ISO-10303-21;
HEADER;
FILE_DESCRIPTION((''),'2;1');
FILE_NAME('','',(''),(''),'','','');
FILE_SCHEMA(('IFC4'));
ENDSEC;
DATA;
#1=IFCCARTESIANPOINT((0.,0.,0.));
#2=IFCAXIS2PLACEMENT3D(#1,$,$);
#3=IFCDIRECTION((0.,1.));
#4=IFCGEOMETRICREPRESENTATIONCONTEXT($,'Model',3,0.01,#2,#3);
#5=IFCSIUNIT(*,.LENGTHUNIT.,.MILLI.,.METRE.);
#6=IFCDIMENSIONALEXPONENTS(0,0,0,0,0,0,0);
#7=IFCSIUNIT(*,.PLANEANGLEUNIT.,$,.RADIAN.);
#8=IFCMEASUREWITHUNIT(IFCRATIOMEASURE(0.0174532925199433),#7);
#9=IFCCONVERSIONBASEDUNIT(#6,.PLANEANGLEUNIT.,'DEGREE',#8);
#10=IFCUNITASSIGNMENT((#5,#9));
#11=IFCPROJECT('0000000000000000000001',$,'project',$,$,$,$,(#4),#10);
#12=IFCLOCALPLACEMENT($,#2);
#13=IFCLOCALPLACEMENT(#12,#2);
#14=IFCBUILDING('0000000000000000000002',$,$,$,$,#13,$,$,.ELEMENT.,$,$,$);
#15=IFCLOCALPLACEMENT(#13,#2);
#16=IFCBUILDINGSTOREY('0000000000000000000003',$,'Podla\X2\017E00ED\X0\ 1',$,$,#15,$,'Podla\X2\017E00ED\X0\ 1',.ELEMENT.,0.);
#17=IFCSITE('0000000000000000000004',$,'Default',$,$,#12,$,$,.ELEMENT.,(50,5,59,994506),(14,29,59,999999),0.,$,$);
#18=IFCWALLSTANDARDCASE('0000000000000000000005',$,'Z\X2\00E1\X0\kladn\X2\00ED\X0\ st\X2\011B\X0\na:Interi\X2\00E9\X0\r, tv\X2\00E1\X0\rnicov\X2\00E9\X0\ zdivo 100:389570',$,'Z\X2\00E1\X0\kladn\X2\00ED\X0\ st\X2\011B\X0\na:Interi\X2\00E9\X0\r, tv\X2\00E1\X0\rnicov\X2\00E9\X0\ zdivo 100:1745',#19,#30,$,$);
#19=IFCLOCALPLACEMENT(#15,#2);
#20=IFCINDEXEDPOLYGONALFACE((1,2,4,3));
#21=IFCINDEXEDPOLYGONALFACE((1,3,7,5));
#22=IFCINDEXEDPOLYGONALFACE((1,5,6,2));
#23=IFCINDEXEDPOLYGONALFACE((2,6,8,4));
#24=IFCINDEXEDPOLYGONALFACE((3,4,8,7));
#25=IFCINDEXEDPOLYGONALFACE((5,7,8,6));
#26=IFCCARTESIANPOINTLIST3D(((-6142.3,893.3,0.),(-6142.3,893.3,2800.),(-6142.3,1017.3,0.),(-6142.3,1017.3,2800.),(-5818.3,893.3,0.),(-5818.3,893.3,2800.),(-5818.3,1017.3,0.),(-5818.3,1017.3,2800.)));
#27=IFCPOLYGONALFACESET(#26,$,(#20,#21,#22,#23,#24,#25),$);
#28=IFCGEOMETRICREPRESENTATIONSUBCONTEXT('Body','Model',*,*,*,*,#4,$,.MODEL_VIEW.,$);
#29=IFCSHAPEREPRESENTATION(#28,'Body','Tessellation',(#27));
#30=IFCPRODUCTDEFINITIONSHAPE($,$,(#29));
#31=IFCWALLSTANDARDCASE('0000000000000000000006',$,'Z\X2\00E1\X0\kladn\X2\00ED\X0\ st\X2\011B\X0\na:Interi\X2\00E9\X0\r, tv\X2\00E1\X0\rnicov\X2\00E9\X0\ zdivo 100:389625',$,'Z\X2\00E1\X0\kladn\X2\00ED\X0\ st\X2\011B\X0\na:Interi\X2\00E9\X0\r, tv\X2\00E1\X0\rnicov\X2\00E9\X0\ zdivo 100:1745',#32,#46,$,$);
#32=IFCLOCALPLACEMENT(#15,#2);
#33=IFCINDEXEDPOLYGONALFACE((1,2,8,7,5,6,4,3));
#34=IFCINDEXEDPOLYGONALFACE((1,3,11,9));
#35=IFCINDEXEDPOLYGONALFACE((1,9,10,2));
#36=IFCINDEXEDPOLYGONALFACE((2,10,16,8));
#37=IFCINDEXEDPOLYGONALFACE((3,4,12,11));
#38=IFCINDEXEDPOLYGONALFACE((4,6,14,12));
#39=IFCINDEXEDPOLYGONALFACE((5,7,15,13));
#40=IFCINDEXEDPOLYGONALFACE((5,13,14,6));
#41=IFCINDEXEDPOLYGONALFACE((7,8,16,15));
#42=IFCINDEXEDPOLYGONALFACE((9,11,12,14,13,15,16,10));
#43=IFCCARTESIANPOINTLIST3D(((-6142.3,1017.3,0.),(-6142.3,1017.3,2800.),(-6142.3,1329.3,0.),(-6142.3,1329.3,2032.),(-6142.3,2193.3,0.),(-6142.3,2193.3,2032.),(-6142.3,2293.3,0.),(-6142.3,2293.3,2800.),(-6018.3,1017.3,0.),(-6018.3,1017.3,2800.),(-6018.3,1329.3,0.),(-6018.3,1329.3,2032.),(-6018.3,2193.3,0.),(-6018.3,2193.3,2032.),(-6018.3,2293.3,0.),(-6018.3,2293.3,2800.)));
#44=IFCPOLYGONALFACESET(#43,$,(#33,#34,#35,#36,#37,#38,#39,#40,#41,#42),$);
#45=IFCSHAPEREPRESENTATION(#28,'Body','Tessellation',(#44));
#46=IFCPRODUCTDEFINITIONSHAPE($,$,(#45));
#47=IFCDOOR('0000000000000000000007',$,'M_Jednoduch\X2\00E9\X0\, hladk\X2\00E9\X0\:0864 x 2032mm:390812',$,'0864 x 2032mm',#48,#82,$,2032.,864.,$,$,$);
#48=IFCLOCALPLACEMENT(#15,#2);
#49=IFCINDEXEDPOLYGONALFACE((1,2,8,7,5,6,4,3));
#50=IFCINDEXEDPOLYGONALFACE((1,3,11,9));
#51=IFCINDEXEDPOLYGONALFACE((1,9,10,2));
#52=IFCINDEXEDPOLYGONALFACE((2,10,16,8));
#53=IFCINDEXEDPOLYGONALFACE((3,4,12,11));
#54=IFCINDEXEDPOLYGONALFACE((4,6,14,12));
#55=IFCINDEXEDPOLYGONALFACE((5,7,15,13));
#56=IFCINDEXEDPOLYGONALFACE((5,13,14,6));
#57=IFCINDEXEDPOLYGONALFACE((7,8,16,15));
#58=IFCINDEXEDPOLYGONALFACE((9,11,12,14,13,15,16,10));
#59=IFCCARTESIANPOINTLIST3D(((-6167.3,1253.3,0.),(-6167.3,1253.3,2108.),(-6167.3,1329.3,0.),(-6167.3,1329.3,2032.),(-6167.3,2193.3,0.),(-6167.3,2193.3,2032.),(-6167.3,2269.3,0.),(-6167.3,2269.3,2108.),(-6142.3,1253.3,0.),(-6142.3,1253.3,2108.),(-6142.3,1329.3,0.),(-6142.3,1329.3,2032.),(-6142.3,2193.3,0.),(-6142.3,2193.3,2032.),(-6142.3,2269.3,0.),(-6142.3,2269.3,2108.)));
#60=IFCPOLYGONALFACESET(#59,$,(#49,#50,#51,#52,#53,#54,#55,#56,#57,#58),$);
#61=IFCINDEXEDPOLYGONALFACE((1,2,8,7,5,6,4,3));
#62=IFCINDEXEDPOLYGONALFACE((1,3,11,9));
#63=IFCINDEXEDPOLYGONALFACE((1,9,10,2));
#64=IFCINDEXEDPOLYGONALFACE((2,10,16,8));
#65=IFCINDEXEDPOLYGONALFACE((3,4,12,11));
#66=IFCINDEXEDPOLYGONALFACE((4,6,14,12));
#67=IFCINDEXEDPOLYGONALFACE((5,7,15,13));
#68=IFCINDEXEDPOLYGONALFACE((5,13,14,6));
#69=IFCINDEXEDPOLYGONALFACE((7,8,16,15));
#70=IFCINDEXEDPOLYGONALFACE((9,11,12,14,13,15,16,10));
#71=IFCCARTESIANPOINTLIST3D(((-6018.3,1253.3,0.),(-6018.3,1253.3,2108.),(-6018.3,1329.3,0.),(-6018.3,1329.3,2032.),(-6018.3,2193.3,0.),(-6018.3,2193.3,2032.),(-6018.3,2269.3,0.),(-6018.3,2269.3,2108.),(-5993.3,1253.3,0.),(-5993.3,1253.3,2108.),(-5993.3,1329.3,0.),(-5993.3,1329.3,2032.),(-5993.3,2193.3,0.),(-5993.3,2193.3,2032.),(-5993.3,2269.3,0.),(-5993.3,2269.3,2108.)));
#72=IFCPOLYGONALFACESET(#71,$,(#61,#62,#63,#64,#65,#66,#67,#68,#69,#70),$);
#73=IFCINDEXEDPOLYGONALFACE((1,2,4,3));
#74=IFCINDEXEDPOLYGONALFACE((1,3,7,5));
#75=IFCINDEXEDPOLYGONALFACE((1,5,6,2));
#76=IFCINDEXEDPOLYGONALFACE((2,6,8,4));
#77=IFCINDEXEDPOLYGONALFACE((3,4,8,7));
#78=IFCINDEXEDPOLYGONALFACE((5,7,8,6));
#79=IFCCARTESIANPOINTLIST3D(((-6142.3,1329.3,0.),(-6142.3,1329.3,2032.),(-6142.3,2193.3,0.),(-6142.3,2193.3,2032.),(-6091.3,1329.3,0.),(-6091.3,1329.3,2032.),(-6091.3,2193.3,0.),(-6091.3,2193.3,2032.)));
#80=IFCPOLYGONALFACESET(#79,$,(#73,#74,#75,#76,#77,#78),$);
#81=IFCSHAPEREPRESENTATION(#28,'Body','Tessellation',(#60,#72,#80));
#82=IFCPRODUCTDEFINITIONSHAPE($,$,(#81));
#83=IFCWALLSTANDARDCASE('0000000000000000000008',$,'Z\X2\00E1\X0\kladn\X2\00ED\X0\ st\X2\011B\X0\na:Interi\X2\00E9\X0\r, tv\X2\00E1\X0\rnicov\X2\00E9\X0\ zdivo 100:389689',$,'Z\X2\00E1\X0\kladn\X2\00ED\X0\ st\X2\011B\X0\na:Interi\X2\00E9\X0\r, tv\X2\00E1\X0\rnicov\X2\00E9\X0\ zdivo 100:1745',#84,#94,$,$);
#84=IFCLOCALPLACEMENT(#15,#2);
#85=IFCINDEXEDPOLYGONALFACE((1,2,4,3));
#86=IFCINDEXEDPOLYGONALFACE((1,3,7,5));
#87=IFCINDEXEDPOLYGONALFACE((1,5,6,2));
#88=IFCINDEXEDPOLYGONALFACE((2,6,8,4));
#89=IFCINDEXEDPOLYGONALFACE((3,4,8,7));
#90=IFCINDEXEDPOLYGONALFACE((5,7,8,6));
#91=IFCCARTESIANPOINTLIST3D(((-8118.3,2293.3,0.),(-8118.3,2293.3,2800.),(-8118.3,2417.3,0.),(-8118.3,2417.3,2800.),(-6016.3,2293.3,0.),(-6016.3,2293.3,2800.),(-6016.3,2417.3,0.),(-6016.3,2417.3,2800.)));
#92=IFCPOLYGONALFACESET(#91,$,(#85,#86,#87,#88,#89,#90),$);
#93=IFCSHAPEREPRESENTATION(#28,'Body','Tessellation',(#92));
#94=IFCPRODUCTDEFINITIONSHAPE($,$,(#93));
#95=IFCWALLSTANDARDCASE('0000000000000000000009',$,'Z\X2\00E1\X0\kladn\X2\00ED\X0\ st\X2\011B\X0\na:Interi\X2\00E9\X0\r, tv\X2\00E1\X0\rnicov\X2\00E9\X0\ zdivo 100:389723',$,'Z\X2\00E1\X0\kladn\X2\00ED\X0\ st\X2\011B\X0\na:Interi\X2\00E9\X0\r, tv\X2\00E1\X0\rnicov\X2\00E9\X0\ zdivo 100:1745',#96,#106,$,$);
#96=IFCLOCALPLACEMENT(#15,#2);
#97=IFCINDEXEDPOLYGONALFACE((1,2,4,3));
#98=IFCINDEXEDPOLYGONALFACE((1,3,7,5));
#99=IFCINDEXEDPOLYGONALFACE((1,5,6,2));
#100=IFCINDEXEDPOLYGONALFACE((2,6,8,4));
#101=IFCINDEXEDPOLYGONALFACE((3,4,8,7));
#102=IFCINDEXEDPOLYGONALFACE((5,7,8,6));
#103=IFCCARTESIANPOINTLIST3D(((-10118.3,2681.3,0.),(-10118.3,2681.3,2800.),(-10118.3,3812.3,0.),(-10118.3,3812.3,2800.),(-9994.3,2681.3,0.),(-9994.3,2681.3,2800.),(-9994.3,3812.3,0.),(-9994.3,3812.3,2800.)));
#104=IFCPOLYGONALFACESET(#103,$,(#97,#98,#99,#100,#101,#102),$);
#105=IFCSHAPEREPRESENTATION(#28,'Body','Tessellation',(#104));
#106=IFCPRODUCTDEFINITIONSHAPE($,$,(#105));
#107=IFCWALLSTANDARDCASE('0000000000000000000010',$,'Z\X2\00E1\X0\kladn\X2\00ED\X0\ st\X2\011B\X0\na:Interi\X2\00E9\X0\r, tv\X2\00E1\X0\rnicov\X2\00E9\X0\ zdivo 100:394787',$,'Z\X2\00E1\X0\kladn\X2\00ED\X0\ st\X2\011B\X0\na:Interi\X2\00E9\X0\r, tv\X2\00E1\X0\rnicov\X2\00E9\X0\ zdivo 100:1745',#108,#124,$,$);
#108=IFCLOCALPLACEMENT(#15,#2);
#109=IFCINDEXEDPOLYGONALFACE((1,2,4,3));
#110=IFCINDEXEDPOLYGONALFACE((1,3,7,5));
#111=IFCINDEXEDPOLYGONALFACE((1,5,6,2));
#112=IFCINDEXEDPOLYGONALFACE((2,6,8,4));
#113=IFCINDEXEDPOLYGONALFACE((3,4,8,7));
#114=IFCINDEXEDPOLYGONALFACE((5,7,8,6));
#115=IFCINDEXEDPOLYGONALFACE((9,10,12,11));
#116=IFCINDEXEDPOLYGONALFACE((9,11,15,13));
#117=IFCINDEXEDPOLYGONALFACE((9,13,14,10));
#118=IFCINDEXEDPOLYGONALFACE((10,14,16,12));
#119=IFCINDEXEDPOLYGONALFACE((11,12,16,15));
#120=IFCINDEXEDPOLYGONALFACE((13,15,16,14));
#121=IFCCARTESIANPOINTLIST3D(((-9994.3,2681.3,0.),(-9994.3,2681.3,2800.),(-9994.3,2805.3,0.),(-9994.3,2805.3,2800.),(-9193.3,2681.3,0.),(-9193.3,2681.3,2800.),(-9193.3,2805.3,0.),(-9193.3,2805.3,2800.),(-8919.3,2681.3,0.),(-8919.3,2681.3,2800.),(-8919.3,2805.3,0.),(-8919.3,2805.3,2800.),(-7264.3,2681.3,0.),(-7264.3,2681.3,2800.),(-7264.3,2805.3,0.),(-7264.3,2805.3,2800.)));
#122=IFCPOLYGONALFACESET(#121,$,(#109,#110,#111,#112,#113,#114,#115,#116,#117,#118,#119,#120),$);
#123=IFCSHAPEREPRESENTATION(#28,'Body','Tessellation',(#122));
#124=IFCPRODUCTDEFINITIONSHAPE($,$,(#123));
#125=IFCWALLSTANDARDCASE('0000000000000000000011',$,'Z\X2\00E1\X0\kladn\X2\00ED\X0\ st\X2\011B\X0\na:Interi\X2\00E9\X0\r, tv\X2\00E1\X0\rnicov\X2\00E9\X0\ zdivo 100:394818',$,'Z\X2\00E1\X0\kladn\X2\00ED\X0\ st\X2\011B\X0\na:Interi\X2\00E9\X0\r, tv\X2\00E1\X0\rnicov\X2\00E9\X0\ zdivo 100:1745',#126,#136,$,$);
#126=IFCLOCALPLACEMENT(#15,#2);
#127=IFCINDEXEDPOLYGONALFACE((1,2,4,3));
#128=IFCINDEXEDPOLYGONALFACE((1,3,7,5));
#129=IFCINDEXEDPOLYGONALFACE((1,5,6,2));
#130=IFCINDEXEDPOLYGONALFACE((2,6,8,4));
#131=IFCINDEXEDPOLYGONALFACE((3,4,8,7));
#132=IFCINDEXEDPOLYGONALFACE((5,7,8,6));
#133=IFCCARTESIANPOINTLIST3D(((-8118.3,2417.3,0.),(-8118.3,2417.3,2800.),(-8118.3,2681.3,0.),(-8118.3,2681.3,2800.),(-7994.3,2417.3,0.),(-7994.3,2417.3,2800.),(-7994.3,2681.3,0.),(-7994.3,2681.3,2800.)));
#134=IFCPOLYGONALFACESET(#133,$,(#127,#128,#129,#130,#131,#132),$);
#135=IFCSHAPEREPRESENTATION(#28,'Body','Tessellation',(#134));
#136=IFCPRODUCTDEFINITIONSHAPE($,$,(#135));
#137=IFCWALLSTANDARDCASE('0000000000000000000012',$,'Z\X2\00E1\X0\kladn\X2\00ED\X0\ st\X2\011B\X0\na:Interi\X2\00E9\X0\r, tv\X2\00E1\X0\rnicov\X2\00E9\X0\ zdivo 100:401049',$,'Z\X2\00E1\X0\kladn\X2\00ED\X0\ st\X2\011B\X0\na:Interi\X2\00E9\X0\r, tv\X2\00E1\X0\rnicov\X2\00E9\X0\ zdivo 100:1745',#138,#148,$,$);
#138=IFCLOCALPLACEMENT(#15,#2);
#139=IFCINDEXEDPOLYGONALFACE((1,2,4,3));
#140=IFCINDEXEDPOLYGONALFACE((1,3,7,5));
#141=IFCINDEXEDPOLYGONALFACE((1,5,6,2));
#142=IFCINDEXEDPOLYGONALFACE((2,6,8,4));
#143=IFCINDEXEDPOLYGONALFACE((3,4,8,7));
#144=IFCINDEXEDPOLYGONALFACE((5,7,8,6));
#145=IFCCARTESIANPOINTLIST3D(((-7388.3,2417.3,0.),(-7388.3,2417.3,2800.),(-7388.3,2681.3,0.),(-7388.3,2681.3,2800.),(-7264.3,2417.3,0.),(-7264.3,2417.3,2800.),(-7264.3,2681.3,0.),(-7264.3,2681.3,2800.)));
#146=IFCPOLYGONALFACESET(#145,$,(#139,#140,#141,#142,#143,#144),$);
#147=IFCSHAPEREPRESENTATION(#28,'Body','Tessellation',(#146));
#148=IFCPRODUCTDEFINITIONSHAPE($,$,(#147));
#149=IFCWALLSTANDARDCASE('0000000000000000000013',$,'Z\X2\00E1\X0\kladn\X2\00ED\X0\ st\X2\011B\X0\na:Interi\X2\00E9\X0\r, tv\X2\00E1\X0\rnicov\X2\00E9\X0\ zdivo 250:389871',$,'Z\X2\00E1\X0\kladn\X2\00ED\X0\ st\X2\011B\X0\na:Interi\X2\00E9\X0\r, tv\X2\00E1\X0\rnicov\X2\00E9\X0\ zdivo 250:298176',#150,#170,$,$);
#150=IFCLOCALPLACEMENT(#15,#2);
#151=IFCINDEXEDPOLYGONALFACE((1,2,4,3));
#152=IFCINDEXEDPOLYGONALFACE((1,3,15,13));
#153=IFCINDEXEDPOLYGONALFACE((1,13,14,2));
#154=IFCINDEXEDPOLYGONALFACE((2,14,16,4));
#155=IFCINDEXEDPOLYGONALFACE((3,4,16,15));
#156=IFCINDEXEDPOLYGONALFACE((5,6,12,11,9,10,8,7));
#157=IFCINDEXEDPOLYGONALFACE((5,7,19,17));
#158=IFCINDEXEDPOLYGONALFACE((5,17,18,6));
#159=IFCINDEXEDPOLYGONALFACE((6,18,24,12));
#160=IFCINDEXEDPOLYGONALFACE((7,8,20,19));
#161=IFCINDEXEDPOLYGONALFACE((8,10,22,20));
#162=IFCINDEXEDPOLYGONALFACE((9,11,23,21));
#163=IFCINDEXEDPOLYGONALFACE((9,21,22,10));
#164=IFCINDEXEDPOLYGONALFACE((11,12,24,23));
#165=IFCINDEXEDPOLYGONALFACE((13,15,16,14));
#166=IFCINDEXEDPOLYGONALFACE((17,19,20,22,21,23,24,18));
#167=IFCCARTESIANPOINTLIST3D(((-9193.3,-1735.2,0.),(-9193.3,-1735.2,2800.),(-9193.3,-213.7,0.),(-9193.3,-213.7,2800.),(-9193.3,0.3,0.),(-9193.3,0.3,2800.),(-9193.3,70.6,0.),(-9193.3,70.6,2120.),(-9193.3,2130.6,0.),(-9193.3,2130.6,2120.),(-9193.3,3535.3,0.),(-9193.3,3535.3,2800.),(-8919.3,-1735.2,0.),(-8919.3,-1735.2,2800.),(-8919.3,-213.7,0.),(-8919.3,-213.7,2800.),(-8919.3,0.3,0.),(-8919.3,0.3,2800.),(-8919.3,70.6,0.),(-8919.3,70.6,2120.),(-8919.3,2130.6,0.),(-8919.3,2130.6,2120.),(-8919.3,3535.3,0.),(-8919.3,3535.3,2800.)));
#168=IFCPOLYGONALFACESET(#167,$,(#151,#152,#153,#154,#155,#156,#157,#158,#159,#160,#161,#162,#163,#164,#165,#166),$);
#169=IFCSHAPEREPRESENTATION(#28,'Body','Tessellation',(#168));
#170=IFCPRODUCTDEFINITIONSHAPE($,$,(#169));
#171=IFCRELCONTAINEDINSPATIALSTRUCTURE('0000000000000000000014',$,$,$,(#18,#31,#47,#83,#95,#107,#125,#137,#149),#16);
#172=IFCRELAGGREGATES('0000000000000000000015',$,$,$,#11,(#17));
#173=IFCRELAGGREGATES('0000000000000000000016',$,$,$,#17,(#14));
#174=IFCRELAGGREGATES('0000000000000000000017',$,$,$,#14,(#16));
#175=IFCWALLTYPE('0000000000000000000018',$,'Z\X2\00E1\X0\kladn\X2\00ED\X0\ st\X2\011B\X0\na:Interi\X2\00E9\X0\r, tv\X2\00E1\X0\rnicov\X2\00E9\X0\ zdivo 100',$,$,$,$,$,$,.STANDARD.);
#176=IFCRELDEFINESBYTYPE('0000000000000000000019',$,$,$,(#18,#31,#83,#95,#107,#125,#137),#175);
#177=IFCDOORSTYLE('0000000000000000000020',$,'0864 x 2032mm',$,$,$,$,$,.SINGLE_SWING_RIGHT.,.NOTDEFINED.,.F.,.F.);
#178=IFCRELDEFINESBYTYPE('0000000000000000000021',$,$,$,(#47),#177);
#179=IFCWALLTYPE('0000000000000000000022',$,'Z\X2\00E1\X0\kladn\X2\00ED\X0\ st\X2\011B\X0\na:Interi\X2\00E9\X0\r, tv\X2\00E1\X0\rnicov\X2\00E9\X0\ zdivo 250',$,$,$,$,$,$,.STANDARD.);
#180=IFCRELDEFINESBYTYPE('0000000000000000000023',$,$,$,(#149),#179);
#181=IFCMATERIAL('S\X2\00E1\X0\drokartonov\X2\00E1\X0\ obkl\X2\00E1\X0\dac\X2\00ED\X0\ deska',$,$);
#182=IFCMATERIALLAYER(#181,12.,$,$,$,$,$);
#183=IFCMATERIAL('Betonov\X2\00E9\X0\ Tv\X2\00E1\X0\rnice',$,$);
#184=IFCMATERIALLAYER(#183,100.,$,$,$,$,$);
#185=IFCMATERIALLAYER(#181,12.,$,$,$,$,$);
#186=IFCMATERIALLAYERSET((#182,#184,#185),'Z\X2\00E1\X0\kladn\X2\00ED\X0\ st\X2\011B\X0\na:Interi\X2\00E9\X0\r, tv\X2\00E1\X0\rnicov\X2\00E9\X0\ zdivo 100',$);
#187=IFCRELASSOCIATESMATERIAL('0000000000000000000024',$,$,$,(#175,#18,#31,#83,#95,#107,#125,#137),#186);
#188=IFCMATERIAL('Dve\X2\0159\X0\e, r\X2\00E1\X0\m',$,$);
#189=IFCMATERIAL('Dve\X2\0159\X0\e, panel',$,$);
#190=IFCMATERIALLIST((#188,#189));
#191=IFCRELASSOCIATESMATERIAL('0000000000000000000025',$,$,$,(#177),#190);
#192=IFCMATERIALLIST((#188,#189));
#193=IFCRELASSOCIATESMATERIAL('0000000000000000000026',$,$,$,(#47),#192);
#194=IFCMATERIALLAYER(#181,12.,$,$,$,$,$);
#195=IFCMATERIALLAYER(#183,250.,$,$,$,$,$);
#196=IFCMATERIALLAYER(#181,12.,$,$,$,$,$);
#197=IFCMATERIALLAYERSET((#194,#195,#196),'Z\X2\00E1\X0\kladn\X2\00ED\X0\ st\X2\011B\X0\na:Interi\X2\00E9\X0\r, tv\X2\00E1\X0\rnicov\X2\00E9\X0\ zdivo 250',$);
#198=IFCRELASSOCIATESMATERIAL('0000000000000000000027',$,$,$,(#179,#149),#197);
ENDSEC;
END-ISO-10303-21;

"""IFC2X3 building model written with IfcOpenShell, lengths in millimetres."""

from ifc_helpers import new_model, entity, si_unit, converted_unit, direction, frame, frame_2d, origin, origin_2d_with_axis, place, context, subcontext, project, spatial, polyline, rectangle, outline, extrude, source, transform, mapped, material, material_list, layer, layer_set, layer_usage, type_object, type_shapes, element, fill, save


model = new_model("IFC2X3")

# Units and contexts
model_context = context("Model", 3, precision=0.01, world=origin(), true_north=direction((0.0, 1.0)))
body_context = subcontext(model_context, "Body", "Model", "MODEL_VIEW")
ifc_project = project(units=[si_unit("LENGTHUNIT", "METRE", prefix="MILLI"), converted_unit("PLANEANGLEUNIT", "DEGREE", entity("IfcRatioMeasure", 0.0174532925199433), si_unit("PLANEANGLEUNIT", "RADIAN"), dimensions=[0, 0, 0, 0, 0, 0, 0])], contexts=[model_context])

# Site, building, storey
site_placement = place(None, origin())
site = spatial("IfcSite", under=ifc_project, at=site_placement, Name="Default", CompositionType="ELEMENT", RefLatitude=(50, 5, 59, 994506), RefLongitude=(14, 29, 59, 999999), RefElevation=0.0)
building_placement = place(site_placement, origin())
building = spatial("IfcBuilding", under=site, at=building_placement, CompositionType="ELEMENT")
storey_placement = place(building_placement, origin())
storey = spatial("IfcBuildingStorey", under=building, at=storey_placement, Name="Podlaží 1", LongName="Podlaží 1", CompositionType="ELEMENT", Elevation=0.0)

# Shared definitions
ifc_material_1 = material(Name="Betonové Tvárnice")
ifc_material_2 = material(Name="Sádrokartonová obkládací deska")

# Shared definitions
ifc_material_3 = material(Name="Dveře, rám")
ifc_material_4 = material(Name="Dveře, panel")

# Wall
ifc_layer_1 = layer(ifc_material_2, 12.0)
ifc_layer_2 = layer(ifc_material_1, 100.0)
ifc_layer_3 = layer(ifc_material_2, 12.0)
ifc_layer_set_1 = layer_set([ifc_layer_1, ifc_layer_2, ifc_layer_3], Name="Základní stěna:Interiér, tvárnicové zdivo 100")
wall_type_1 = type_object("IfcWallType", Name="Základní stěna:Interiér, tvárnicové zdivo 100", PredefinedType="STANDARD", material=ifc_layer_set_1)
ifc_layer_usage_1 = layer_usage(ifc_layer_set_1, "AXIS2", "NEGATIVE", 62.0)
wall_1_placement = place(storey_placement, frame((-5818.3, 955.3, 0.0), z_axis=(0.0, 0.0, 1.0), x_axis=(-1.0, 0.0, 0.0)))
element("IfcWallStandardCase", 1, at=wall_1_placement, inside=storey, type_object=wall_type_1, material=ifc_layer_usage_1, Name="Základní stěna:Interiér, tvárnicové zdivo 100:389570", ObjectType="Základní stěna:Interiér, tvárnicové zdivo 100:1745", context=body_context, shape_type="SweptSolid", body=[
    extrude(rectangle(XDim=324.0, YDim=124.0, at=frame_2d((162.0, 0.0), x_axis=(-1.0, 0.0))), origin(), (0.0, 0.0, 1.0), 2800.0),
])

# Wall, opening, door
ifc_layer_usage_2 = layer_usage(ifc_layer_set_1, "AXIS2", "NEGATIVE", 62.0)
wall_2_placement = place(storey_placement, frame((-6080.3, 1017.3, 0.0), z_axis=(0.0, 0.0, 1.0), x_axis=(0.0, 1.0, 0.0)))
wall_2 = element("IfcWallStandardCase", 2, at=wall_2_placement, inside=storey, type_object=wall_type_1, material=ifc_layer_usage_2, Name="Základní stěna:Interiér, tvárnicové zdivo 100:389625", ObjectType="Základní stěna:Interiér, tvárnicové zdivo 100:1745", context=body_context, shape_type="SweptSolid", body=[
    extrude(rectangle(XDim=1276.0, YDim=124.0, at=frame_2d((638.0, 0.0), x_axis=(-1.0, 0.0))), origin(), (0.0, 0.0, 1.0), 2800.0),
])
opening_1_placement = place(wall_2_placement, frame((312.0, -62.0, 0.0)))
opening_1 = element("IfcOpeningElement", 3, at=opening_1_placement, cuts=wall_2, ObjectType="Opening", context=body_context, shape_type="SweptSolid", body=[
    extrude(rectangle(XDim=864.0, YDim=2032.0, at=frame_2d((1016.0, 432.0), x_axis=(0.0, 1.0))), frame((0.0, 0.0, 0.0), z_axis=(0.0, 1.0, 0.0), x_axis=(0.0, 0.0, 1.0)), (0.0, 0.0, 1.0), 124.0),
])
ifc_material_list_1 = material_list([ifc_material_3, ifc_material_4])
ifc_material_list_2 = material_list([ifc_material_3, ifc_material_4])
door_style_1 = type_object("IfcDoorStyle", Name="0864 x 2032mm", ConstructionType="NOTDEFINED", OperationType="SINGLE_SWING_RIGHT", ParameterTakesPrecedence=False, Sizeable=False, material=ifc_material_list_2)
shared_shape_1 = source(origin(), body_context, "Body", "SweptSolid", [
    extrude(outline(polyline([(-508.0, -1073.0), (508.0, -1073.0), (508.0, 1035.0), (432.0, 1035.0), (432.0, -997.0), (-432.0, -997.0), (-432.0, 1035.0), (-508.0, 1035.0), (-508.0, -1073.0)])), frame((432.0, 124.0, 1035.0), z_axis=(0.0, 1.0, 0.0), x_axis=(1.0, 0.0, 0.0)), (0.0, 0.0, 1.0), 25.0),
    extrude(outline(polyline([(-1073.0, -508.0), (1035.0, -508.0), (1035.0, -432.0), (-997.0, -432.0), (-997.0, 432.0), (1035.0, 432.0), (1035.0, 508.0), (-1073.0, 508.0), (-1073.0, -508.0)])), frame((432.0, -25.0, 1035.0), z_axis=(0.0, 1.0, 0.0), x_axis=(0.0, 0.0, -1.0)), (0.0, 0.0, 1.0), 25.0),
    extrude(rectangle(XDim=51.0, YDim=864.0, at=origin_2d_with_axis()), frame((432.0, 98.5, 0.0), z_axis=(0.0, 0.0, 1.0), x_axis=(0.0, 1.0, 0.0)), (0.0, 0.0, 1.0), 2032.0),
])
type_shapes(door_style_1, [shared_shape_1])
door_1_placement = place(opening_1_placement, origin())
door_1 = element("IfcDoor", 4, at=door_1_placement, inside=storey, type_object=door_style_1, material=ifc_material_list_1, Name="M_Jednoduché, hladké:0864 x 2032mm:390812", ObjectType="0864 x 2032mm", OverallHeight=2032.0, OverallWidth=864.0, context=body_context, shape_type="MappedRepresentation", body=[
    mapped(shared_shape_1, transform((0.0, 0.0, 0.0), scale=1.0)),
])
fill(opening_1, door_1)

# Walls
ifc_layer_usage_3 = layer_usage(ifc_layer_set_1, "AXIS2", "NEGATIVE", 62.0)
wall_3_placement = place(storey_placement, frame((-6016.3, 2355.3, 0.0), z_axis=(0.0, 0.0, 1.0), x_axis=(-1.0, 0.0, 0.0)))
element("IfcWallStandardCase", 5, at=wall_3_placement, inside=storey, type_object=wall_type_1, material=ifc_layer_usage_3, Name="Základní stěna:Interiér, tvárnicové zdivo 100:389689", ObjectType="Základní stěna:Interiér, tvárnicové zdivo 100:1745", context=body_context, shape_type="SweptSolid", body=[
    extrude(rectangle(XDim=2102.0, YDim=124.0, at=frame_2d((1051.0, 0.0), x_axis=(-1.0, 0.0))), origin(), (0.0, 0.0, 1.0), 2800.0),
])
ifc_layer_usage_4 = layer_usage(ifc_layer_set_1, "AXIS2", "NEGATIVE", 62.0)
wall_4_placement = place(storey_placement, frame((-10056.3, 2681.3, 0.0), z_axis=(0.0, 0.0, 1.0), x_axis=(0.0, 1.0, 0.0)))
element("IfcWallStandardCase", 6, at=wall_4_placement, inside=storey, type_object=wall_type_1, material=ifc_layer_usage_4, Name="Základní stěna:Interiér, tvárnicové zdivo 100:389723", ObjectType="Základní stěna:Interiér, tvárnicové zdivo 100:1745", context=body_context, shape_type="SweptSolid", body=[
    extrude(rectangle(XDim=1131.0, YDim=124.0, at=frame_2d((565.5, 0.0), x_axis=(-1.0, 0.0))), origin(), (0.0, 0.0, 1.0), 2800.0),
])

# Wall, opening
ifc_layer_usage_5 = layer_usage(ifc_layer_set_1, "AXIS2", "NEGATIVE", 62.0)
wall_5_placement = place(storey_placement, frame((-9994.3, 2743.3, 0.0)))
wall_5 = element("IfcWallStandardCase", 7, at=wall_5_placement, inside=storey, type_object=wall_type_1, material=ifc_layer_usage_5, Name="Základní stěna:Interiér, tvárnicové zdivo 100:394787", ObjectType="Základní stěna:Interiér, tvárnicové zdivo 100:1745", context=body_context, shape_type="SweptSolid", body=[
    extrude(rectangle(XDim=2730.0, YDim=124.0, at=frame_2d((1365.0, 0.0), x_axis=(-1.0, 0.0))), origin(), (0.0, 0.0, 1.0), 2800.0),
])
opening_2_placement = place(storey_placement, frame((-9994.3, 2743.3, 0.0)))
element("IfcOpeningElement", 8, at=opening_2_placement, cuts=wall_5, ObjectType="Opening", context=body_context, shape_type="SweptSolid", body=[
    extrude(rectangle(XDim=2800.0, YDim=124.0, at=origin_2d_with_axis()), frame((801.0, 0.0, 1400.0), z_axis=(1.0, 0.0, 0.0), x_axis=(0.0, 0.0, -1.0)), (0.0, 0.0, 1.0), 274.0),
])

# Walls
ifc_layer_usage_6 = layer_usage(ifc_layer_set_1, "AXIS2", "NEGATIVE", 62.0)
wall_6_placement = place(storey_placement, frame((-8056.3, 2681.3, 0.0), z_axis=(0.0, 0.0, 1.0), x_axis=(0.0, -1.0, 0.0)))
element("IfcWallStandardCase", 9, at=wall_6_placement, inside=storey, type_object=wall_type_1, material=ifc_layer_usage_6, Name="Základní stěna:Interiér, tvárnicové zdivo 100:394818", ObjectType="Základní stěna:Interiér, tvárnicové zdivo 100:1745", context=body_context, shape_type="SweptSolid", body=[
    extrude(rectangle(XDim=264.0, YDim=124.0, at=frame_2d((132.0, 0.0), x_axis=(-1.0, 0.0))), origin(), (0.0, 0.0, 1.0), 2800.0),
])
ifc_layer_usage_7 = layer_usage(ifc_layer_set_1, "AXIS2", "NEGATIVE", 62.0)
wall_7_placement = place(storey_placement, frame((-7326.3, 2681.3, 0.0), z_axis=(0.0, 0.0, 1.0), x_axis=(0.0, -1.0, 0.0)))
element("IfcWallStandardCase", 10, at=wall_7_placement, inside=storey, type_object=wall_type_1, material=ifc_layer_usage_7, Name="Základní stěna:Interiér, tvárnicové zdivo 100:401049", ObjectType="Základní stěna:Interiér, tvárnicové zdivo 100:1745", context=body_context, shape_type="SweptSolid", body=[
    extrude(rectangle(XDim=264.0, YDim=124.0, at=frame_2d((132.0, 0.0), x_axis=(-1.0, 0.0))), origin(), (0.0, 0.0, 1.0), 2800.0),
])

# Wall, openings
ifc_layer_4 = layer(ifc_material_2, 12.0)
ifc_layer_5 = layer(ifc_material_1, 250.0)
ifc_layer_6 = layer(ifc_material_2, 12.0)
ifc_layer_set_2 = layer_set([ifc_layer_4, ifc_layer_5, ifc_layer_6], Name="Základní stěna:Interiér, tvárnicové zdivo 250")
ifc_layer_usage_8 = layer_usage(ifc_layer_set_2, "AXIS2", "NEGATIVE", 137.0)
wall_type_2 = type_object("IfcWallType", Name="Základní stěna:Interiér, tvárnicové zdivo 250", PredefinedType="STANDARD", material=ifc_layer_set_2)
wall_8_placement = place(storey_placement, frame((-9056.3, 3535.3, 0.0), z_axis=(0.0, 0.0, 1.0), x_axis=(0.0, -1.0, 0.0)))
wall_8 = element("IfcWallStandardCase", 11, at=wall_8_placement, inside=storey, type_object=wall_type_2, material=ifc_layer_usage_8, Name="Základní stěna:Interiér, tvárnicové zdivo 250:389871", ObjectType="Základní stěna:Interiér, tvárnicové zdivo 250:298176", context=body_context, shape_type="SweptSolid", body=[
    extrude(rectangle(XDim=5270.5, YDim=274.0, at=frame_2d((2635.2, 0.0), x_axis=(-1.0, 0.0))), origin(), (0.0, 0.0, 1.0), 2800.0),
])
opening_3_placement = place(storey_placement, frame((-9056.3, 3535.3, 0.0), z_axis=(0.0, 0.0, 1.0), x_axis=(0.0, -1.0, 0.0)))
element("IfcOpeningElement", 12, at=opening_3_placement, cuts=wall_8, ObjectType="Opening", context=body_context, shape_type="SweptSolid", body=[
    extrude(rectangle(XDim=2800.0, YDim=274.0, at=origin_2d_with_axis()), frame((3749.0, 0.0, 1400.0), z_axis=(-1.0, 0.0, 0.0), x_axis=(0.0, 0.0, 1.0)), (0.0, 0.0, 1.0), 214.0),
])
opening_4_placement = place(wall_8_placement, origin())
element("IfcOpeningElement", 13, at=opening_4_placement, cuts=wall_8, ObjectType="Opening", context=body_context, shape_type="SweptSolid", body=[
    extrude(rectangle(XDim=2120.0, YDim=2060.0, at=origin_2d_with_axis()), frame((2434.8, -137.0, 1060.0), z_axis=(0.0, 1.0, 0.0), x_axis=(0.0, 0.0, -1.0)), (0.0, 0.0, 1.0), 274.0),
])

save(model, "model.ifc")
